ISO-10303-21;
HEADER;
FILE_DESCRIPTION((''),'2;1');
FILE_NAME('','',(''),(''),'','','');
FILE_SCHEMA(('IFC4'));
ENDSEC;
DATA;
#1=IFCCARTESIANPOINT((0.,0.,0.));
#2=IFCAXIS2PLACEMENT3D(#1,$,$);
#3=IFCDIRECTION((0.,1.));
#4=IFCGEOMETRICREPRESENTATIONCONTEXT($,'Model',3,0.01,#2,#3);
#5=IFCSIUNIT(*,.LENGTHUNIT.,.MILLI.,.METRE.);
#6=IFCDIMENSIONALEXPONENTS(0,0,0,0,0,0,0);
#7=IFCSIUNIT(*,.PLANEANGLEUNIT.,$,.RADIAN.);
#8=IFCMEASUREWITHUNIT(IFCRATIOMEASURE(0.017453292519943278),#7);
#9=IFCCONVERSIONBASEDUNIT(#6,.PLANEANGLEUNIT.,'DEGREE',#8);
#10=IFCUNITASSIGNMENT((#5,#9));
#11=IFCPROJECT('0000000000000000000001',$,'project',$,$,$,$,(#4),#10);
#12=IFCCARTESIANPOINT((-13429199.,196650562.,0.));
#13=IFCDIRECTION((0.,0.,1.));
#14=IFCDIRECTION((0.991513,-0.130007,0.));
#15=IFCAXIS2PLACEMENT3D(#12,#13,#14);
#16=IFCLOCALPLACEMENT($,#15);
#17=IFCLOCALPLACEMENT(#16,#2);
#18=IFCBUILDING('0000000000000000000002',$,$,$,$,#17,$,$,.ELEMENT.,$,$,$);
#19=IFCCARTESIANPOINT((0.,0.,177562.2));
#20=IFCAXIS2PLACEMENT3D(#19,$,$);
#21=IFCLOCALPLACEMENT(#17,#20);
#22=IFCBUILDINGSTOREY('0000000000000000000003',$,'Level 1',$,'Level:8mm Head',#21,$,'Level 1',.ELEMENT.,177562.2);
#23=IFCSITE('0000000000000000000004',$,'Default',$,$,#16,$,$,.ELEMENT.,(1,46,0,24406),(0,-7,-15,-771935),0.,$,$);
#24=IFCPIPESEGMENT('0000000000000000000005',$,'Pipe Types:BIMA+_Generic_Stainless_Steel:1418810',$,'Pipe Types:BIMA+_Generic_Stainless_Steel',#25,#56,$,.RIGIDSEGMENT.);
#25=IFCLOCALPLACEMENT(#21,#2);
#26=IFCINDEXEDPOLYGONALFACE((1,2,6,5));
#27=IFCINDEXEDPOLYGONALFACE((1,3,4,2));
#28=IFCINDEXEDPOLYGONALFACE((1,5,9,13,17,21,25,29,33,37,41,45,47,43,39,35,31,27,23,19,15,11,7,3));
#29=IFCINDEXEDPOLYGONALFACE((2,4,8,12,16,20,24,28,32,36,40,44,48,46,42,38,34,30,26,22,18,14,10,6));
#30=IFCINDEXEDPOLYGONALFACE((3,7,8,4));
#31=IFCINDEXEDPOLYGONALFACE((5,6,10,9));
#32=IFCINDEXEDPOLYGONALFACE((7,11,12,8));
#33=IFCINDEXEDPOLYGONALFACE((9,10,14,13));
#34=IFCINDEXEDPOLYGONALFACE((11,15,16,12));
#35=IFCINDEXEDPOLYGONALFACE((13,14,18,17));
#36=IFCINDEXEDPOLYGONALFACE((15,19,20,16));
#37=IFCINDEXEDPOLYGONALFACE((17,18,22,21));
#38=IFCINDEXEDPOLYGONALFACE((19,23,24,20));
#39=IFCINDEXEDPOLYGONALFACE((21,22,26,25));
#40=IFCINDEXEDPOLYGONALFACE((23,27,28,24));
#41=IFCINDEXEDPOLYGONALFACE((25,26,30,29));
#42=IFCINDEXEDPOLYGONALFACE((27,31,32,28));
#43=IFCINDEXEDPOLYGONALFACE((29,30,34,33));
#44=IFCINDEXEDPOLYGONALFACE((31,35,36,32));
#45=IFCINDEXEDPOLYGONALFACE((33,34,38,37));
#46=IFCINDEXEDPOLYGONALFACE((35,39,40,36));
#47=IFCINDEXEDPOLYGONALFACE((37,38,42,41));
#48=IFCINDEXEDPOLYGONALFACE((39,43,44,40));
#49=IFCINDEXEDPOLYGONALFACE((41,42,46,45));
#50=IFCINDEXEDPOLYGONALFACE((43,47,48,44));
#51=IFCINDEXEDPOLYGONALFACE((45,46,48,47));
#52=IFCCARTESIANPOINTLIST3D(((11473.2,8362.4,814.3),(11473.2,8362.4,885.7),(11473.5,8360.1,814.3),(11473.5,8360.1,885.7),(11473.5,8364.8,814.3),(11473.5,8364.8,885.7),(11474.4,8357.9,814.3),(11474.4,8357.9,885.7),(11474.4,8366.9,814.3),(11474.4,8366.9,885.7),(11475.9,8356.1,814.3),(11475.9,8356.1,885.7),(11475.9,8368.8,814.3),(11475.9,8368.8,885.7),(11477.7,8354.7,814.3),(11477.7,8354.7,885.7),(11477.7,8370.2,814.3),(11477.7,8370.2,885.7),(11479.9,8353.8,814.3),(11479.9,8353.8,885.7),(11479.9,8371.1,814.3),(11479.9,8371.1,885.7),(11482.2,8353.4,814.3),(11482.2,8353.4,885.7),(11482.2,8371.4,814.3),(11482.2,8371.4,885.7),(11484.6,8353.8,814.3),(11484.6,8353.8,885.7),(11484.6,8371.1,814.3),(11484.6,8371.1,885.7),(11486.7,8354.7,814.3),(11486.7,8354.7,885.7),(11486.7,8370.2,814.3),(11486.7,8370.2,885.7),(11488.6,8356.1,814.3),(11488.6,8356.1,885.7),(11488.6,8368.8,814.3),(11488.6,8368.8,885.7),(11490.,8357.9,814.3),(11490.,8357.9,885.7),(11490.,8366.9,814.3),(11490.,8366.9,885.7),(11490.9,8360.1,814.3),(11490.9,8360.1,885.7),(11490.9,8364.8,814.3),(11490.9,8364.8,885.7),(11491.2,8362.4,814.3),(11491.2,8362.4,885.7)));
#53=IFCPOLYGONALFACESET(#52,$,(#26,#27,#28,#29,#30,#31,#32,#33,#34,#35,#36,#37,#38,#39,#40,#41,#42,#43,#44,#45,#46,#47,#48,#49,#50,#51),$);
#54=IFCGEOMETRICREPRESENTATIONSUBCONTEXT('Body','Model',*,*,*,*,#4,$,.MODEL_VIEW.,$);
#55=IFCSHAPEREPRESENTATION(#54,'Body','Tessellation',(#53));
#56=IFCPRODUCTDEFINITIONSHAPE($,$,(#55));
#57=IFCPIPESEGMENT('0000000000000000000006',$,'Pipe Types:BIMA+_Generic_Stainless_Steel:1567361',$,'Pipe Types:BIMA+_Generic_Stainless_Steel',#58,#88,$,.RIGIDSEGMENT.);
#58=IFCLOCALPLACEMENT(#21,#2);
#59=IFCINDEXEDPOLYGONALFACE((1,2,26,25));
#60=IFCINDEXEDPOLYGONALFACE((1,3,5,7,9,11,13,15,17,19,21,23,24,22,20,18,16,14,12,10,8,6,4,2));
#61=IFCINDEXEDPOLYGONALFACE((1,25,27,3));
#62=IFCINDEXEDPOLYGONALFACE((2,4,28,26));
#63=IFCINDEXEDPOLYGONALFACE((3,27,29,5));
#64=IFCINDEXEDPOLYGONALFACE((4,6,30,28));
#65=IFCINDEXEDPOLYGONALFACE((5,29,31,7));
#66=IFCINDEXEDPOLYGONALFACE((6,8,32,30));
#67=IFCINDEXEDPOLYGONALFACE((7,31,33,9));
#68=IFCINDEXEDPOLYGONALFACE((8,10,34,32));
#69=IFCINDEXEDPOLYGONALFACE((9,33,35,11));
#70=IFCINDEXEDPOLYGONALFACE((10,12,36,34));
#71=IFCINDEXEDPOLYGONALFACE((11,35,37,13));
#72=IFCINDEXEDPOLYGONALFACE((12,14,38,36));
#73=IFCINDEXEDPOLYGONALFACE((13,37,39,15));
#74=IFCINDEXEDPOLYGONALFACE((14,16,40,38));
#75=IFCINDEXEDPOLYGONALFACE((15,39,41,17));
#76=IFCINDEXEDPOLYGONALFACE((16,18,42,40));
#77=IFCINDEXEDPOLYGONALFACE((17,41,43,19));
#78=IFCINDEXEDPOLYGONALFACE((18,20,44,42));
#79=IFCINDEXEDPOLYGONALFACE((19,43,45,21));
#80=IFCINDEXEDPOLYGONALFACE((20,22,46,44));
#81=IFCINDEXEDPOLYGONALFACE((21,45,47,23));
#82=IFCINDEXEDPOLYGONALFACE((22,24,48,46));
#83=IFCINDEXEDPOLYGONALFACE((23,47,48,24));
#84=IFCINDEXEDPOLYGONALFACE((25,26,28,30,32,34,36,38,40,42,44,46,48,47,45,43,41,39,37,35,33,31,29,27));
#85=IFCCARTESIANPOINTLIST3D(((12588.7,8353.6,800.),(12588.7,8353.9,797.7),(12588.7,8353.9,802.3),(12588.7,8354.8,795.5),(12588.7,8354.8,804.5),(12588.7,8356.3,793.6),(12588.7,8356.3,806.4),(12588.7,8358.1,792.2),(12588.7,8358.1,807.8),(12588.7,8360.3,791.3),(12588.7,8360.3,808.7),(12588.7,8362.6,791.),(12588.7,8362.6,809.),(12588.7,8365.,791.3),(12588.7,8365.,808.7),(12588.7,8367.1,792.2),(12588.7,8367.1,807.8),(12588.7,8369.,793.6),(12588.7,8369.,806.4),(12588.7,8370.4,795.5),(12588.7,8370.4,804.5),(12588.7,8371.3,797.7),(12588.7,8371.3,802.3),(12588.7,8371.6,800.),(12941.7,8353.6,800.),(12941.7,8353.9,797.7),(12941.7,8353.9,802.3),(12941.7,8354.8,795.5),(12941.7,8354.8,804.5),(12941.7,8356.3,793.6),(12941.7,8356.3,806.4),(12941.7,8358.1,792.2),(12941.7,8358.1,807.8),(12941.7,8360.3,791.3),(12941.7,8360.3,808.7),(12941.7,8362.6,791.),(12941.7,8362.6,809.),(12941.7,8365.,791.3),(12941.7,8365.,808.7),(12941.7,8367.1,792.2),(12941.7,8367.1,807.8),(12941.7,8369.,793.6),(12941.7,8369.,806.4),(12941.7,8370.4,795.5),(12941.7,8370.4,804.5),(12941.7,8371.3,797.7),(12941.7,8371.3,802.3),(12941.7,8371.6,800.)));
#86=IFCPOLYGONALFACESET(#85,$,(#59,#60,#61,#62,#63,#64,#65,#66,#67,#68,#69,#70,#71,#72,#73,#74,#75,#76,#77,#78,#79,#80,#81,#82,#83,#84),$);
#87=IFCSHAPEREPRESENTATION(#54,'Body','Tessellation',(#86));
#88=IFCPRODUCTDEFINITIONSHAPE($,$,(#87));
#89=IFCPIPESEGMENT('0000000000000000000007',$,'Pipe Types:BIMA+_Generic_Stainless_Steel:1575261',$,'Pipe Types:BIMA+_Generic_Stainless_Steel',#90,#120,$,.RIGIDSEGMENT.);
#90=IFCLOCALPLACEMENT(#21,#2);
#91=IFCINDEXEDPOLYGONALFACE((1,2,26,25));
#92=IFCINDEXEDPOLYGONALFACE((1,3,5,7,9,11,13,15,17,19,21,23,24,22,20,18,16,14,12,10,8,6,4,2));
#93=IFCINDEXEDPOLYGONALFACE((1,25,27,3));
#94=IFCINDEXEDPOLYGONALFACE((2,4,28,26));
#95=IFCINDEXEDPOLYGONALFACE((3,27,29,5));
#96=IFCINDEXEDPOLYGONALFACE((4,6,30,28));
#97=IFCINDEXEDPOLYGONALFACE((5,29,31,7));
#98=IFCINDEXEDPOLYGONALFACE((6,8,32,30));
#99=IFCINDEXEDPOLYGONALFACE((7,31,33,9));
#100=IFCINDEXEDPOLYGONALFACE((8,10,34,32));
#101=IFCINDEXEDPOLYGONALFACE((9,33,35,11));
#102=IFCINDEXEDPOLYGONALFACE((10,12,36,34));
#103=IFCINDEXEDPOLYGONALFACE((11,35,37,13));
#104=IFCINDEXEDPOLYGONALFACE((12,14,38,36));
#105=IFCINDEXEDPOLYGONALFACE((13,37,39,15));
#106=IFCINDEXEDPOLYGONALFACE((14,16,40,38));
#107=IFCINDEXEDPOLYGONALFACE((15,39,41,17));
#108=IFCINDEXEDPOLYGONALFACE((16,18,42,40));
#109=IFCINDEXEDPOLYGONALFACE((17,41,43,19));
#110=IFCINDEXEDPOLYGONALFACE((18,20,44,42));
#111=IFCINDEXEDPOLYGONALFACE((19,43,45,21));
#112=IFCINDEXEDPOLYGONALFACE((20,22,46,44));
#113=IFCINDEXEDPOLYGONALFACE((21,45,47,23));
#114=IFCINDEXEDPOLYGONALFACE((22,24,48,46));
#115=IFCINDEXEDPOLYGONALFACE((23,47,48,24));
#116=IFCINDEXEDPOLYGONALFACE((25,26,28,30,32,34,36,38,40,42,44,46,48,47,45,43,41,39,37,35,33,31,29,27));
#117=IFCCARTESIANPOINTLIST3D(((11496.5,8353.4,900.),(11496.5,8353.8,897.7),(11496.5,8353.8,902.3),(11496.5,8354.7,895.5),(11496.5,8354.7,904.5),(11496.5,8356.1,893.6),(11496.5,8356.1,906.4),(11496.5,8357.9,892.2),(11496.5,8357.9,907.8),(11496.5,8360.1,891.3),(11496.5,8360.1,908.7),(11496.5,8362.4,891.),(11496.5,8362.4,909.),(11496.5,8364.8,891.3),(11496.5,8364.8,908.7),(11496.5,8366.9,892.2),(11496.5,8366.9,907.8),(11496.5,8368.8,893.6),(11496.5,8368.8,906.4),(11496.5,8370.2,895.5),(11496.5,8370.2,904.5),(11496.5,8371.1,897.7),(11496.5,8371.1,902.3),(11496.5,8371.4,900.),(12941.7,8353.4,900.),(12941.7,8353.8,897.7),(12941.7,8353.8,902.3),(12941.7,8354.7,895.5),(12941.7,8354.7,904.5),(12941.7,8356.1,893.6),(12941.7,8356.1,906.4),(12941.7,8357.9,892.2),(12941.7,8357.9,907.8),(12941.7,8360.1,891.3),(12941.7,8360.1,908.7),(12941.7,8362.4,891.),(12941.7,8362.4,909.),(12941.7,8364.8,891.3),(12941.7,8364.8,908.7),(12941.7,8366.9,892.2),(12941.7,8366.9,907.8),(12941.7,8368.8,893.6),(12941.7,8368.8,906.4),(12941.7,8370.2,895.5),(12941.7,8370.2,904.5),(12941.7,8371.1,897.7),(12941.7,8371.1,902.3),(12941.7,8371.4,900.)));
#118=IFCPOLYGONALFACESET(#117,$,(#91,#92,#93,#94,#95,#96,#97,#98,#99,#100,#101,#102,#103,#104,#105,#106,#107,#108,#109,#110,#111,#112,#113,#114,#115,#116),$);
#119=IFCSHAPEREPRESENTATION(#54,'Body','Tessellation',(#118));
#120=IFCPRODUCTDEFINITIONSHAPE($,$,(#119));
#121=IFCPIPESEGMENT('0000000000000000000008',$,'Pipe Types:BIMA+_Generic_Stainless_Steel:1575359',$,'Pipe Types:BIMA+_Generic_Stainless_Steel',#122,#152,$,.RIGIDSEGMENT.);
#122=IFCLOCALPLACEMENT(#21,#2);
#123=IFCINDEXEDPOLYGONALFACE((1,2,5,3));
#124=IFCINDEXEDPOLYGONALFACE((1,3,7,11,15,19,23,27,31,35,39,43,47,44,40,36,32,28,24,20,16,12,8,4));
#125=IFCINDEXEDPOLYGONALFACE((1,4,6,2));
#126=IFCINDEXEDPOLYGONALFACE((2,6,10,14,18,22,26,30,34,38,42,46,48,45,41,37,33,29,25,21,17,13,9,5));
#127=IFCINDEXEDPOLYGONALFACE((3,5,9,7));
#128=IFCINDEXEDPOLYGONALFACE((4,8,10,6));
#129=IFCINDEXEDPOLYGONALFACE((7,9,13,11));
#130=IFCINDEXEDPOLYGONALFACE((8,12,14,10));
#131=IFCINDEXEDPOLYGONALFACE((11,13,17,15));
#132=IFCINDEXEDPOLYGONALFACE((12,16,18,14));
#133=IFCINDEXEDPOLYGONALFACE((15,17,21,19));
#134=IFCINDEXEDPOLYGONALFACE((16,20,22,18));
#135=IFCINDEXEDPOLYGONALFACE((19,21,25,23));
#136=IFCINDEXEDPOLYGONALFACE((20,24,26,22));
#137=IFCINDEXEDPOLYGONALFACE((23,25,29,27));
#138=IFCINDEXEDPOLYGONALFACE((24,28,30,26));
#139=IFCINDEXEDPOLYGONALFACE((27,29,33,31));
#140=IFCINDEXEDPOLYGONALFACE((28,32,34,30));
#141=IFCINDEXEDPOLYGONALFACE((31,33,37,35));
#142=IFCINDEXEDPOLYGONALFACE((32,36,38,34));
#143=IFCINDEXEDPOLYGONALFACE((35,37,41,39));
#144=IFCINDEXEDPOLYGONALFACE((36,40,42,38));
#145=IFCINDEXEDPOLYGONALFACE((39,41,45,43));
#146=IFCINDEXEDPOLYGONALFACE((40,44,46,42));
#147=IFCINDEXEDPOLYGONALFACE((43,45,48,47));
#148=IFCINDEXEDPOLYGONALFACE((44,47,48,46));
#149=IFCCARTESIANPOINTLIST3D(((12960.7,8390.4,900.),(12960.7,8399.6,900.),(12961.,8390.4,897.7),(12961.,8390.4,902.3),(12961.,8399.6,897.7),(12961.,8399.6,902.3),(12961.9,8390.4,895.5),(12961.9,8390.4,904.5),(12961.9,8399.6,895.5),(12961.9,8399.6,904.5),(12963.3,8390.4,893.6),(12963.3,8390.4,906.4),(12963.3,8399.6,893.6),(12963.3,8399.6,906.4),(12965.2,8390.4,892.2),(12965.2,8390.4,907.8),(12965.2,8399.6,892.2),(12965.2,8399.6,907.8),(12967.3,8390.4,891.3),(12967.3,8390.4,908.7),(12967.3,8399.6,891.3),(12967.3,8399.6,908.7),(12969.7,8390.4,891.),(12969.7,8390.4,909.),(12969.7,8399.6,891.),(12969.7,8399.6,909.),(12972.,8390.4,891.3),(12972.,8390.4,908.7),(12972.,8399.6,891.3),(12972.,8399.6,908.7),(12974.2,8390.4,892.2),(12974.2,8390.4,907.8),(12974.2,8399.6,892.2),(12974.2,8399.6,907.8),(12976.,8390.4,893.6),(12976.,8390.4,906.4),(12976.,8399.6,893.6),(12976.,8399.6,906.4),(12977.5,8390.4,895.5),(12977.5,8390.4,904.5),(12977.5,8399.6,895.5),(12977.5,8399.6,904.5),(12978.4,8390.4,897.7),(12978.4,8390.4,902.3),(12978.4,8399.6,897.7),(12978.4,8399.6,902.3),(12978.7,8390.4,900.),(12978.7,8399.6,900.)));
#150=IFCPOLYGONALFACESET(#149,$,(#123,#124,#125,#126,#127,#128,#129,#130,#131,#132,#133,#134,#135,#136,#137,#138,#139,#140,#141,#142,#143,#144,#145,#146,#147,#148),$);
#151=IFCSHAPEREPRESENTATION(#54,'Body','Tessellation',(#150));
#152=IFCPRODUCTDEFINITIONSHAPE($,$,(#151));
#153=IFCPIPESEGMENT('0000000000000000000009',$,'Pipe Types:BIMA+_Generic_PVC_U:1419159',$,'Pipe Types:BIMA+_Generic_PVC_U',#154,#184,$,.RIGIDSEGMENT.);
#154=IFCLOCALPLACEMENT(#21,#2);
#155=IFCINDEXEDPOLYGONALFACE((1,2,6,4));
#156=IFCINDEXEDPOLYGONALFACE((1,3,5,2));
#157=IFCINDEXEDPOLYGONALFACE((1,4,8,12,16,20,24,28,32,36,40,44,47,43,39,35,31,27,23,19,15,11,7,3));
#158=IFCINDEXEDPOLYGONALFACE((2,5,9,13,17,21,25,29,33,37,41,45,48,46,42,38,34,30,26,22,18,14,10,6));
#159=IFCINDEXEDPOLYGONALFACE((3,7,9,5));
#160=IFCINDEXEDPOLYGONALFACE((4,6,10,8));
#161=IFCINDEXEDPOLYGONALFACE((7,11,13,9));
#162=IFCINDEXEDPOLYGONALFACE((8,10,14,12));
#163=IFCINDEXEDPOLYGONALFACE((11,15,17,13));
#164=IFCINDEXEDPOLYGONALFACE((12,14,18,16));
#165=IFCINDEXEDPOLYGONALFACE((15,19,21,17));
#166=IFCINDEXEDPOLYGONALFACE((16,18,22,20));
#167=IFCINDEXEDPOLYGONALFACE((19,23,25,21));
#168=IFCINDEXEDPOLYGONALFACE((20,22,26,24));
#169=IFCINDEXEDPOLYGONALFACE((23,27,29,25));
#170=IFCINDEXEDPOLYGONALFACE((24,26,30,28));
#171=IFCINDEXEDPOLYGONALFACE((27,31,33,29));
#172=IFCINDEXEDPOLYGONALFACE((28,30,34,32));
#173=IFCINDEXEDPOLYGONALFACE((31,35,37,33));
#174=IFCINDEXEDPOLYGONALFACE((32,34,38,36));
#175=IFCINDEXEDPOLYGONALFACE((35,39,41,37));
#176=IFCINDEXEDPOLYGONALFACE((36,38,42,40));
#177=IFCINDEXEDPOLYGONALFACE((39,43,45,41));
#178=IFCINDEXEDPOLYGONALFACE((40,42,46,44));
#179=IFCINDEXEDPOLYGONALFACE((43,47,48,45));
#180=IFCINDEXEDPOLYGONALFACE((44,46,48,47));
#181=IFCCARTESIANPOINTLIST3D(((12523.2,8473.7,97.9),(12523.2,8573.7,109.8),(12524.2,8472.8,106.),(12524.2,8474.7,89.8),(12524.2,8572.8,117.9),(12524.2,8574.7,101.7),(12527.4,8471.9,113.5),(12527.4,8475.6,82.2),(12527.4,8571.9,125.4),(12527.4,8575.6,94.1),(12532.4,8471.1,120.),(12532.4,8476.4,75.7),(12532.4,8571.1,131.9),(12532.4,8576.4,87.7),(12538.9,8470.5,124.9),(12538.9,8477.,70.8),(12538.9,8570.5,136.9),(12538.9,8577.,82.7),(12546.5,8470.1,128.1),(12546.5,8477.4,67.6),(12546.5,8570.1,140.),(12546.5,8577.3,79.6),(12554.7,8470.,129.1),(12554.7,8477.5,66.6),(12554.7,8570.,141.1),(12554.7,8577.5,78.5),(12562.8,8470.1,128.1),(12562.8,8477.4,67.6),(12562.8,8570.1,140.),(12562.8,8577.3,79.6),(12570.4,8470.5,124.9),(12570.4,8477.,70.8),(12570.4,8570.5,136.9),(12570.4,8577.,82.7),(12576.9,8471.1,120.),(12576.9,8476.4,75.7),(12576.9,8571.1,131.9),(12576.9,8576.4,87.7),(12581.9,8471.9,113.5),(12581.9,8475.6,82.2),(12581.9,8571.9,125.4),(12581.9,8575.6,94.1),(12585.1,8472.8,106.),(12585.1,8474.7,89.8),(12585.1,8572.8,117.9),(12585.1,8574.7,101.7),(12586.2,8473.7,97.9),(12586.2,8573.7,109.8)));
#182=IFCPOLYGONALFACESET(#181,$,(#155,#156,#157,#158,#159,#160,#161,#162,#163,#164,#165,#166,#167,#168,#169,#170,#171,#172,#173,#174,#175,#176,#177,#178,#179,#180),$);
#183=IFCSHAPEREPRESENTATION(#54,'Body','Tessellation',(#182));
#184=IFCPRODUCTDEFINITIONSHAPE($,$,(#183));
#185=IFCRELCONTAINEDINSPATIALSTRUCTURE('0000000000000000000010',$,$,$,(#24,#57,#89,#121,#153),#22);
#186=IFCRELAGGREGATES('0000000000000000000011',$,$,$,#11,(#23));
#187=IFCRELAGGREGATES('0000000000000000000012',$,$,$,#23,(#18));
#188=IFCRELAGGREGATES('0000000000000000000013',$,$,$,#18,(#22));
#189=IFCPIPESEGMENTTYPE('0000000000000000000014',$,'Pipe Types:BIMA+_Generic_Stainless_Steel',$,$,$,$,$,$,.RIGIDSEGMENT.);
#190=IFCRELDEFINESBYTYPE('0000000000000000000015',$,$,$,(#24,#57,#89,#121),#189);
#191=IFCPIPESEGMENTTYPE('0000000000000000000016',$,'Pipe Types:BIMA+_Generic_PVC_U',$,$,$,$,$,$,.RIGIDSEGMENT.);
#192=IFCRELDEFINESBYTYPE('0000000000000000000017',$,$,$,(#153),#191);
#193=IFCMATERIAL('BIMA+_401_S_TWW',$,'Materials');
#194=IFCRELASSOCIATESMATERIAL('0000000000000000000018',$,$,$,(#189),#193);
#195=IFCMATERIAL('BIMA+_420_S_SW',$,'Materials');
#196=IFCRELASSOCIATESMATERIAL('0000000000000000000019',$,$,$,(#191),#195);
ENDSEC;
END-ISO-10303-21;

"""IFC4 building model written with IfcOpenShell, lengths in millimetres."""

from ifc_helpers import new_model, entity, si_unit, converted_unit, direction, frame, origin, place, context, subcontext, project, spatial, arc, indexed_curve, outline, extrude, material, type_object, element, save


model = new_model("IFC4")

# Units and contexts
model_context = context("Model", 3, precision=0.01, world=origin(), true_north=direction((0.0, 1.0)))
body_context = subcontext(model_context, "Body", "Model", "MODEL_VIEW")
ifc_project = project(units=[si_unit("LENGTHUNIT", "METRE", prefix="MILLI"), converted_unit("PLANEANGLEUNIT", "DEGREE", entity("IfcRatioMeasure", 0.017453292519943278), si_unit("PLANEANGLEUNIT", "RADIAN"), dimensions=[0, 0, 0, 0, 0, 0, 0])], contexts=[model_context])

# Site, building, storey
site_placement = place(None, frame((-13429199.0, 196650562.0, 0.0), z_axis=(0.0, 0.0, 1.0), x_axis=(0.991513, -0.130007, 0.0)))
site = spatial("IfcSite", under=ifc_project, at=site_placement, Name="Default", CompositionType="ELEMENT", RefLatitude=(1, 46, 0, 24406), RefLongitude=(0, -7, -15, -771935), RefElevation=0.0)
building_placement = place(site_placement, origin())
building = spatial("IfcBuilding", under=site, at=building_placement, CompositionType="ELEMENT")
storey_placement = place(building_placement, frame((0.0, 0.0, 177562.2)))
storey = spatial("IfcBuildingStorey", under=building, at=storey_placement, Name="Level 1", ObjectType="Level:8mm Head", LongName="Level 1", CompositionType="ELEMENT", Elevation=177562.2)

# Pipe segments
ifc_material_1 = material(Name="BIMA+_401_S_TWW", Category="Materials")
pipe_segment_type_1 = type_object("IfcPipeSegmentType", Name="Pipe Types:BIMA+_Generic_Stainless_Steel", PredefinedType="RIGIDSEGMENT", material=ifc_material_1)
pipe_segment_1_placement = place(storey_placement, frame((11471.6, 8351.9, 814.3)))
element("IfcPipeSegment", 1, at=pipe_segment_1_placement, inside=storey, type_object=pipe_segment_type_1, Name="Pipe Types:BIMA+_Generic_Stainless_Steel:1418810", ObjectType="Pipe Types:BIMA+_Generic_Stainless_Steel", PredefinedType="RIGIDSEGMENT", context=body_context, shape_type="SweptSolid", body=[
    extrude(outline(indexed_curve([(9.0, 0.0), (6.4, 6.4), (0.0, 9.0), (-6.4, 6.4), (-9.0, 0.0), (-6.4, -6.4), (0.0, -9.0), (6.4, -6.4)], segments=[arc(1, 2, 3), arc(3, 4, 5), arc(5, 6, 7), arc(7, 8, 1)], self_intersect=False)), frame((10.6, 10.6, 0.0), z_axis=(0.0, 0.0, 1.0), x_axis=(-1.0, 0.0, 0.0)), (0.0, 0.0, 1.0), 71.4),
])
pipe_segment_2_placement = place(storey_placement, frame((12588.7, 8352.0, 789.4)))
element("IfcPipeSegment", 2, at=pipe_segment_2_placement, inside=storey, type_object=pipe_segment_type_1, Name="Pipe Types:BIMA+_Generic_Stainless_Steel:1567361", ObjectType="Pipe Types:BIMA+_Generic_Stainless_Steel", PredefinedType="RIGIDSEGMENT", context=body_context, shape_type="SweptSolid", body=[
    extrude(outline(indexed_curve([(9.0, 0.0), (6.4, 6.4), (0.0, 9.0), (-6.4, 6.4), (-9.0, 0.0), (-6.4, -6.4), (0.0, -9.0), (6.4, -6.4)], segments=[arc(1, 2, 3), arc(3, 4, 5), arc(5, 6, 7), arc(7, 8, 1)], self_intersect=False)), frame((0.0, 10.6, 10.6), z_axis=(1.0, 0.0, 0.0), x_axis=(0.0, -1.0, 0.0)), (0.0, 0.0, 1.0), 353.0),
])
pipe_segment_3_placement = place(storey_placement, frame((11496.5, 8351.9, 889.4)))
element("IfcPipeSegment", 3, at=pipe_segment_3_placement, inside=storey, type_object=pipe_segment_type_1, Name="Pipe Types:BIMA+_Generic_Stainless_Steel:1575261", ObjectType="Pipe Types:BIMA+_Generic_Stainless_Steel", PredefinedType="RIGIDSEGMENT", context=body_context, shape_type="SweptSolid", body=[
    extrude(outline(indexed_curve([(9.0, 0.0), (6.4, 6.4), (0.0, 9.0), (-6.4, 6.4), (-9.0, 0.0), (-6.4, -6.4), (0.0, -9.0), (6.4, -6.4)], segments=[arc(1, 2, 3), arc(3, 4, 5), arc(5, 6, 7), arc(7, 8, 1)], self_intersect=False)), frame((0.0, 10.6, 10.6), z_axis=(1.0, 0.0, 0.0), x_axis=(0.0, -1.0, 0.0)), (0.0, 0.0, 1.0), 1445.1),
])
pipe_segment_4_placement = place(storey_placement, frame((12959.1, 8390.4, 889.4)))
element("IfcPipeSegment", 4, at=pipe_segment_4_placement, inside=storey, type_object=pipe_segment_type_1, Name="Pipe Types:BIMA+_Generic_Stainless_Steel:1575359", ObjectType="Pipe Types:BIMA+_Generic_Stainless_Steel", PredefinedType="RIGIDSEGMENT", context=body_context, shape_type="SweptSolid", body=[
    extrude(outline(indexed_curve([(9.0, 0.0), (6.4, 6.4), (0.0, 9.0), (-6.4, 6.4), (-9.0, 0.0), (-6.4, -6.4), (0.0, -9.0), (6.4, -6.4)], segments=[arc(1, 2, 3), arc(3, 4, 5), arc(5, 6, 7), arc(7, 8, 1)], self_intersect=False)), frame((10.6, 0.0, 10.6), z_axis=(0.0, 1.0, 0.0), x_axis=(1.0, 0.0, 0.0)), (0.0, 0.0, 1.0), 9.2),
])
ifc_material_2 = material(Name="BIMA+_420_S_SW", Category="Materials")
pipe_segment_type_2 = type_object("IfcPipeSegmentType", Name="Pipe Types:BIMA+_Generic_PVC_U", PredefinedType="RIGIDSEGMENT", material=ifc_material_2)
pipe_segment_5_placement = place(storey_placement, frame((12521.6, 8468.4, 142.7)))
element("IfcPipeSegment", 5, at=pipe_segment_5_placement, inside=storey, type_object=pipe_segment_type_2, Name="Pipe Types:BIMA+_Generic_PVC_U:1419159", ObjectType="Pipe Types:BIMA+_Generic_PVC_U", PredefinedType="RIGIDSEGMENT", context=body_context, shape_type="SweptSolid", body=[
    extrude(outline(indexed_curve([(31.5, 0.0), (22.3, 22.3), (0.0, 31.5), (-22.3, 22.3), (-31.5, 0.0), (-22.3, -22.3), (0.0, -31.5), (22.3, -22.3)], segments=[arc(1, 2, 3), arc(3, 4, 5), arc(5, 6, 7), arc(7, 8, 1)], self_intersect=False)), frame((33.1, 105.3, -32.9), z_axis=(0.000028, -0.992967, -0.11839), x_axis=(-1.0, -0.000029, 0.0)), (0.0, 0.0, 1.0), 100.7),
])

save(model, "model.ifc")
